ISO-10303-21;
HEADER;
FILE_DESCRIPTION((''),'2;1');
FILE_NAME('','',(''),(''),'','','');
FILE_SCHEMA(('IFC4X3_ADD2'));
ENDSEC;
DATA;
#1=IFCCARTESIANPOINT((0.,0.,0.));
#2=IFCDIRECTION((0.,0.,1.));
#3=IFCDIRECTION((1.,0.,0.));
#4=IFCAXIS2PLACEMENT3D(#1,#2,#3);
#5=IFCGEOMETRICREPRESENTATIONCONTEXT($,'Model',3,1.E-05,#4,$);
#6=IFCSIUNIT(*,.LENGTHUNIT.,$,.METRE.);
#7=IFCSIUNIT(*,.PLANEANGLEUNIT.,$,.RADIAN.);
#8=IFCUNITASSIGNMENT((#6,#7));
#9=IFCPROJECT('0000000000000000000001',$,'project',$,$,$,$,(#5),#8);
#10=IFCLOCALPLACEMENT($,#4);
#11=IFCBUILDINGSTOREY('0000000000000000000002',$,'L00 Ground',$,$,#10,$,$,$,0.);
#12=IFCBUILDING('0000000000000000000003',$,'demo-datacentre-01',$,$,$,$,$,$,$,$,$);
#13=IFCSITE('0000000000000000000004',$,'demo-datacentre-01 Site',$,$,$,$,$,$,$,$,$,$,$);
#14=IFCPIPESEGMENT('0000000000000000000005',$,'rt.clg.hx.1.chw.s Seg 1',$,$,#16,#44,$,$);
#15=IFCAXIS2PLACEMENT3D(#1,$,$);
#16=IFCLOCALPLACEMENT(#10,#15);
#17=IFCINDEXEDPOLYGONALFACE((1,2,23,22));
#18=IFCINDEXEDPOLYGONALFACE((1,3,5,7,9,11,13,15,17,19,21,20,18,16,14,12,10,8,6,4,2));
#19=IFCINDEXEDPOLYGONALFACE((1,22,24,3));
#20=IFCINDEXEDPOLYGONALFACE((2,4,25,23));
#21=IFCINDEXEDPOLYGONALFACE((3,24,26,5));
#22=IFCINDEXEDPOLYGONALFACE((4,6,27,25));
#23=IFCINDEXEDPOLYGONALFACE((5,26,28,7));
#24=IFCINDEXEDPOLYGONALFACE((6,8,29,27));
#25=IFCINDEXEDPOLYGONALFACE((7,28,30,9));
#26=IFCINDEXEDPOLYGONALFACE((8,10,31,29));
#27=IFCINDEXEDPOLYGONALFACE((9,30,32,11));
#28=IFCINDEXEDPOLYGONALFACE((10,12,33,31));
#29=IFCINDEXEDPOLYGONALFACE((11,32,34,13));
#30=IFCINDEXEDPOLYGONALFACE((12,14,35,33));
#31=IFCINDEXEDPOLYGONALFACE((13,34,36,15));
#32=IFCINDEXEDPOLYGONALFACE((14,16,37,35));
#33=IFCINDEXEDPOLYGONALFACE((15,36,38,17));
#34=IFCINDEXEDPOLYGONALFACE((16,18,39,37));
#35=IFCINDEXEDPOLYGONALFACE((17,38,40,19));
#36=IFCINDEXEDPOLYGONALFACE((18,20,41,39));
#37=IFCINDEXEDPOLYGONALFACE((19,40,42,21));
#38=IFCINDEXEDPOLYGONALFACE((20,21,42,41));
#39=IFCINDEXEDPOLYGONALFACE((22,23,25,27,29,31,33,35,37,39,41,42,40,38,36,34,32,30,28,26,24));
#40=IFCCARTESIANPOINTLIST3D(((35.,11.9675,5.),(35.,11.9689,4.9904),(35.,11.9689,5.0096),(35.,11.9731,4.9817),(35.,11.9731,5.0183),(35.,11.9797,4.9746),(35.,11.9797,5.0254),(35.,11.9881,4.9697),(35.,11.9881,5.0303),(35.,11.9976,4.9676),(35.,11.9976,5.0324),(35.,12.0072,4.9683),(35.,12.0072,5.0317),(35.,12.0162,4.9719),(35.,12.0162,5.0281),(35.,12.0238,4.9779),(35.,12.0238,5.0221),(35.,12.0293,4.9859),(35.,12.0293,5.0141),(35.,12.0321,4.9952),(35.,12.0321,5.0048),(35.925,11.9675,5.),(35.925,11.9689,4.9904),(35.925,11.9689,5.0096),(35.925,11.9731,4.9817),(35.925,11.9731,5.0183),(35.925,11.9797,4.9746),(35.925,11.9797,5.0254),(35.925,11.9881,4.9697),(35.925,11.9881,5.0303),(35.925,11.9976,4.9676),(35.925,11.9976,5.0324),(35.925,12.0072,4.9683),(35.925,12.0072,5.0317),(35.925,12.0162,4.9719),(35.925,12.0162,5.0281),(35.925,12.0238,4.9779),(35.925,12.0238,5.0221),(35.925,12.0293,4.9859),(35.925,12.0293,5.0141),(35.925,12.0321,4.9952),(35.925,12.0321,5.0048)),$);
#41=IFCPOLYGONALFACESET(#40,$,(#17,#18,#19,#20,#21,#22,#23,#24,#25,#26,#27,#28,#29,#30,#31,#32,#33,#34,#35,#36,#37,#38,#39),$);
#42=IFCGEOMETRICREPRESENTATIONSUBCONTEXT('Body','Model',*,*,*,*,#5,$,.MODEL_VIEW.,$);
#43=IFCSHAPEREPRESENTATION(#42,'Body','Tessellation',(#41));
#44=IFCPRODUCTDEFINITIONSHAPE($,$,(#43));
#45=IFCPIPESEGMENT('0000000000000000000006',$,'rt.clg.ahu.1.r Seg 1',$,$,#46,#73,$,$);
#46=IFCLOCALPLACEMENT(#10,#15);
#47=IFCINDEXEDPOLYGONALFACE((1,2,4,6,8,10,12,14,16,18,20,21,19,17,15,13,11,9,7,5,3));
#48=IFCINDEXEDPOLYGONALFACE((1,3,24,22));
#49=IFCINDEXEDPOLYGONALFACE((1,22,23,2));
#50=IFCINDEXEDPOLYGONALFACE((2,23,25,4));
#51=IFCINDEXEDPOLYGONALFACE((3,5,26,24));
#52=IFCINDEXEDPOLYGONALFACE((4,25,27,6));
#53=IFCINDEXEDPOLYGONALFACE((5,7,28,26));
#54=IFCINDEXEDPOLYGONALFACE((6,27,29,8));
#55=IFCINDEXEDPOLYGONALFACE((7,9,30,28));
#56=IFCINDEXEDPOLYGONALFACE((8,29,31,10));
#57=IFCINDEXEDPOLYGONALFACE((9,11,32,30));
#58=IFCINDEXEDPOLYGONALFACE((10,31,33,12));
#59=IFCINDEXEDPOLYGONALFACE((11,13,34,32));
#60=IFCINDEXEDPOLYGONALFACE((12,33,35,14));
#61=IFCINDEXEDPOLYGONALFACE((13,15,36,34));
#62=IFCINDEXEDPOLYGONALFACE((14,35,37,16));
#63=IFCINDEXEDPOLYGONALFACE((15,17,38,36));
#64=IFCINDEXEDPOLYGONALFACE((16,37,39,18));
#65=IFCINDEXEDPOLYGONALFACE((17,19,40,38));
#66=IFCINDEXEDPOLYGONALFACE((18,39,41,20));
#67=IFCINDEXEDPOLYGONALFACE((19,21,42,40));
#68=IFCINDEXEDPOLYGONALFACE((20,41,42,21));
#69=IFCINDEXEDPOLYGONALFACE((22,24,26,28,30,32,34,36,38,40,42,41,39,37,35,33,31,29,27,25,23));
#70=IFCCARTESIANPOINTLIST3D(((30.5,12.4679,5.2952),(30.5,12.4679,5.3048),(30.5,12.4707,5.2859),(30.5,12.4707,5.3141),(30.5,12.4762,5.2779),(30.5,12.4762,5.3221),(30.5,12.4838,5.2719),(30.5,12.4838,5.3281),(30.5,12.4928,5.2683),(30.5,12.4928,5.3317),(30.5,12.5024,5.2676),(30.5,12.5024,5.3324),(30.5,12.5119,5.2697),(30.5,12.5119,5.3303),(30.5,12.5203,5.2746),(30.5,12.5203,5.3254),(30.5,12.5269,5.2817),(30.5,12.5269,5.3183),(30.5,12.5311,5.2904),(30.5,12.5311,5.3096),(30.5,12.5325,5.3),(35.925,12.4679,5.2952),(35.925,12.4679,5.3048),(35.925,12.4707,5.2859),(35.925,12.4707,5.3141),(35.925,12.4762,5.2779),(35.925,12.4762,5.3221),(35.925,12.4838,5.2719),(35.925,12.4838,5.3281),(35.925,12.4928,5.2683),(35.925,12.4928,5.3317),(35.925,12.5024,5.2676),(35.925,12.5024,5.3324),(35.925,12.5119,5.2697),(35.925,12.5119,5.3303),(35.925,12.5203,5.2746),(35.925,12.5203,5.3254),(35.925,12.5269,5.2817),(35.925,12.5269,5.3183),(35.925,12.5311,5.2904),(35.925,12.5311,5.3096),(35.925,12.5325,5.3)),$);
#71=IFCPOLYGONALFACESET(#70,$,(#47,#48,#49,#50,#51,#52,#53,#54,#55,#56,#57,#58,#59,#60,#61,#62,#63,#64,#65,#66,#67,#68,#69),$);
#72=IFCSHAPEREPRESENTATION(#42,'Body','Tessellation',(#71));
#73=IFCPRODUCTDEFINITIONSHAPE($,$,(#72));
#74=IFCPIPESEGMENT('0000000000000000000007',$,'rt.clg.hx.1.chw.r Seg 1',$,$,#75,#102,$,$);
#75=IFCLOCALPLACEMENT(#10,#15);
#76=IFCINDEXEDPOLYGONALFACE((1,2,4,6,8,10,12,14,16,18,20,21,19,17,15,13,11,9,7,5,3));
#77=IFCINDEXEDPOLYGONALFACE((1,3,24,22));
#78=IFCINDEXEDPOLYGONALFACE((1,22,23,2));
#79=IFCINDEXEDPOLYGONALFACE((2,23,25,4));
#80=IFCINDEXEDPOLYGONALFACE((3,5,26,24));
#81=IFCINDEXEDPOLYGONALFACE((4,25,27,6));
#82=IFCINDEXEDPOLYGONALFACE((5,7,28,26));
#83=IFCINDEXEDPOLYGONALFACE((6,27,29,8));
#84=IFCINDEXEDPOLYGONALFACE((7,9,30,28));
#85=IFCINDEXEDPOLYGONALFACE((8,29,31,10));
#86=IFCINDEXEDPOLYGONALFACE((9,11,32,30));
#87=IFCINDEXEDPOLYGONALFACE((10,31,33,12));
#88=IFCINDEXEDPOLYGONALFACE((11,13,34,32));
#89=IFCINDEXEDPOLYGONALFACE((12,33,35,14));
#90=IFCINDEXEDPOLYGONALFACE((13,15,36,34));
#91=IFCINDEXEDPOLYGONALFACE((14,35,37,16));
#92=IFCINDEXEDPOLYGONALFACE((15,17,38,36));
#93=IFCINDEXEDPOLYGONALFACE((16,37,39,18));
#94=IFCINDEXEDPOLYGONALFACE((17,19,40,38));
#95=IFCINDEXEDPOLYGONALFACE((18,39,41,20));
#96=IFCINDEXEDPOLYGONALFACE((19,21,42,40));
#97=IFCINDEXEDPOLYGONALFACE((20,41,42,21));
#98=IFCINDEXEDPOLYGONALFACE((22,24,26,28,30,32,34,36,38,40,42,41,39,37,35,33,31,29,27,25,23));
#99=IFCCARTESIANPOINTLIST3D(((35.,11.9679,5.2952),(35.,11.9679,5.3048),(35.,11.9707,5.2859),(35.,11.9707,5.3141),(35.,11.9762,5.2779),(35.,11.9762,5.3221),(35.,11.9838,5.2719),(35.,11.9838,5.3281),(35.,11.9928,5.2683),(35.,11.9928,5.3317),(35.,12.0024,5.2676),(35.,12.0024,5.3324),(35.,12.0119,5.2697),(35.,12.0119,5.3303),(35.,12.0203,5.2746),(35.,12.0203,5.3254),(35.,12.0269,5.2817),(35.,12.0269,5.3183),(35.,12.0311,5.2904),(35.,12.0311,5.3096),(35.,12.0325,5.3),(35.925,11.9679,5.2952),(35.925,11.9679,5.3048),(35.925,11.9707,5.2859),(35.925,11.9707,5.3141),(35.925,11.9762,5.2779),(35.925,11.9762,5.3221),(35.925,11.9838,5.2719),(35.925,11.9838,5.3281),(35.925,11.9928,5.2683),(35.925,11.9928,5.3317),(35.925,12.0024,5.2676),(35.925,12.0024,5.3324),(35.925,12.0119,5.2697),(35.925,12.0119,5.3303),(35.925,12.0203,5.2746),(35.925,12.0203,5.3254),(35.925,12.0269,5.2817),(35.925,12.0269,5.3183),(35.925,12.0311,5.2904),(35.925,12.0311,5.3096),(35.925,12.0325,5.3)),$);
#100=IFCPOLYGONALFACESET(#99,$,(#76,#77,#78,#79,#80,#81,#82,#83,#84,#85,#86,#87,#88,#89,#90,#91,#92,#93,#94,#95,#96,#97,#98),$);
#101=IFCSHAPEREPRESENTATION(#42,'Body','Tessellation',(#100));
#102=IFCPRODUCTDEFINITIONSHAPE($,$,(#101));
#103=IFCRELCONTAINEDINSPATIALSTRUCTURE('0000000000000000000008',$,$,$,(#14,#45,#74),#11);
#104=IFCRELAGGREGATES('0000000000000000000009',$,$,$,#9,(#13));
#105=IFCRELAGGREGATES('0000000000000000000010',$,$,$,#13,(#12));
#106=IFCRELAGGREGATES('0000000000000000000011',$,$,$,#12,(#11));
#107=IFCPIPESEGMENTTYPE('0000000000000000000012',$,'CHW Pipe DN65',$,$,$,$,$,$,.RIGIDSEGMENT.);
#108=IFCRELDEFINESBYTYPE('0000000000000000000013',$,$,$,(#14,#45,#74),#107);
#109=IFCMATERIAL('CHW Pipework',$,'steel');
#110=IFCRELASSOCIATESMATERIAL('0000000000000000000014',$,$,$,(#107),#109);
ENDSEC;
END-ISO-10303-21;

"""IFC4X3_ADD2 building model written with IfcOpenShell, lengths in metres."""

from ifc_helpers import new_model, si_unit, frame, origin_with_axes, place, context, subcontext, project, spatial, circle, extrude, material, type_object, element, save


model = new_model("IFC4X3_ADD2")

# Units and contexts
model_context = context("Model", 3, precision=1e-05, world=origin_with_axes())
body_context = subcontext(model_context, "Body", "Model", "MODEL_VIEW")
ifc_project = project(units=[si_unit("LENGTHUNIT", "METRE"), si_unit("PLANEANGLEUNIT", "RADIAN")], contexts=[model_context])

# Site, building, storey
site = spatial("IfcSite", under=ifc_project, Name="demo-datacentre-01 Site")
building = spatial("IfcBuilding", under=site, Name="demo-datacentre-01")
storey_placement = place(None, origin_with_axes())
storey = spatial("IfcBuildingStorey", under=building, at=storey_placement, Name="L00 Ground", Elevation=0.0)

# Shared definitions
ifc_material_1 = material(Name="CHW Pipework", Category="steel")

# Pipe segments
pipe_segment_type_1 = type_object("IfcPipeSegmentType", Name="CHW Pipe DN65", PredefinedType="RIGIDSEGMENT", material=ifc_material_1)
pipe_segment_1_placement = place(storey_placement, frame((35.925, 12.0, 5.0), z_axis=(-1.0, 0.0, 0.0), x_axis=(0.0, -1.0, 0.0)))
element("IfcPipeSegment", 1, at=pipe_segment_1_placement, inside=storey, type_object=pipe_segment_type_1, Name="rt.clg.hx.1.chw.s Seg 1", context=body_context, shape_type="SweptSolid", body=[
    extrude(circle(Radius=0.0325), origin_with_axes(), (0.0, 0.0, 1.0), 0.925),
])
pipe_segment_2_placement = place(storey_placement, frame((30.5, 12.5, 5.3), z_axis=(1.0, 0.0, 0.0), x_axis=(0.0, 1.0, 0.0)))
element("IfcPipeSegment", 2, at=pipe_segment_2_placement, inside=storey, type_object=pipe_segment_type_1, Name="rt.clg.ahu.1.r Seg 1", context=body_context, shape_type="SweptSolid", body=[
    extrude(circle(Radius=0.0325), origin_with_axes(), (0.0, 0.0, 1.0), 5.425),
])
pipe_segment_3_placement = place(storey_placement, frame((35.0, 12.0, 5.3), z_axis=(1.0, 0.0, 0.0), x_axis=(0.0, 1.0, 0.0)))
element("IfcPipeSegment", 3, at=pipe_segment_3_placement, inside=storey, type_object=pipe_segment_type_1, Name="rt.clg.hx.1.chw.r Seg 1", context=body_context, shape_type="SweptSolid", body=[
    extrude(circle(Radius=0.0325), origin_with_axes(), (0.0, 0.0, 1.0), 0.925),
])

save(model, "model.ifc")
